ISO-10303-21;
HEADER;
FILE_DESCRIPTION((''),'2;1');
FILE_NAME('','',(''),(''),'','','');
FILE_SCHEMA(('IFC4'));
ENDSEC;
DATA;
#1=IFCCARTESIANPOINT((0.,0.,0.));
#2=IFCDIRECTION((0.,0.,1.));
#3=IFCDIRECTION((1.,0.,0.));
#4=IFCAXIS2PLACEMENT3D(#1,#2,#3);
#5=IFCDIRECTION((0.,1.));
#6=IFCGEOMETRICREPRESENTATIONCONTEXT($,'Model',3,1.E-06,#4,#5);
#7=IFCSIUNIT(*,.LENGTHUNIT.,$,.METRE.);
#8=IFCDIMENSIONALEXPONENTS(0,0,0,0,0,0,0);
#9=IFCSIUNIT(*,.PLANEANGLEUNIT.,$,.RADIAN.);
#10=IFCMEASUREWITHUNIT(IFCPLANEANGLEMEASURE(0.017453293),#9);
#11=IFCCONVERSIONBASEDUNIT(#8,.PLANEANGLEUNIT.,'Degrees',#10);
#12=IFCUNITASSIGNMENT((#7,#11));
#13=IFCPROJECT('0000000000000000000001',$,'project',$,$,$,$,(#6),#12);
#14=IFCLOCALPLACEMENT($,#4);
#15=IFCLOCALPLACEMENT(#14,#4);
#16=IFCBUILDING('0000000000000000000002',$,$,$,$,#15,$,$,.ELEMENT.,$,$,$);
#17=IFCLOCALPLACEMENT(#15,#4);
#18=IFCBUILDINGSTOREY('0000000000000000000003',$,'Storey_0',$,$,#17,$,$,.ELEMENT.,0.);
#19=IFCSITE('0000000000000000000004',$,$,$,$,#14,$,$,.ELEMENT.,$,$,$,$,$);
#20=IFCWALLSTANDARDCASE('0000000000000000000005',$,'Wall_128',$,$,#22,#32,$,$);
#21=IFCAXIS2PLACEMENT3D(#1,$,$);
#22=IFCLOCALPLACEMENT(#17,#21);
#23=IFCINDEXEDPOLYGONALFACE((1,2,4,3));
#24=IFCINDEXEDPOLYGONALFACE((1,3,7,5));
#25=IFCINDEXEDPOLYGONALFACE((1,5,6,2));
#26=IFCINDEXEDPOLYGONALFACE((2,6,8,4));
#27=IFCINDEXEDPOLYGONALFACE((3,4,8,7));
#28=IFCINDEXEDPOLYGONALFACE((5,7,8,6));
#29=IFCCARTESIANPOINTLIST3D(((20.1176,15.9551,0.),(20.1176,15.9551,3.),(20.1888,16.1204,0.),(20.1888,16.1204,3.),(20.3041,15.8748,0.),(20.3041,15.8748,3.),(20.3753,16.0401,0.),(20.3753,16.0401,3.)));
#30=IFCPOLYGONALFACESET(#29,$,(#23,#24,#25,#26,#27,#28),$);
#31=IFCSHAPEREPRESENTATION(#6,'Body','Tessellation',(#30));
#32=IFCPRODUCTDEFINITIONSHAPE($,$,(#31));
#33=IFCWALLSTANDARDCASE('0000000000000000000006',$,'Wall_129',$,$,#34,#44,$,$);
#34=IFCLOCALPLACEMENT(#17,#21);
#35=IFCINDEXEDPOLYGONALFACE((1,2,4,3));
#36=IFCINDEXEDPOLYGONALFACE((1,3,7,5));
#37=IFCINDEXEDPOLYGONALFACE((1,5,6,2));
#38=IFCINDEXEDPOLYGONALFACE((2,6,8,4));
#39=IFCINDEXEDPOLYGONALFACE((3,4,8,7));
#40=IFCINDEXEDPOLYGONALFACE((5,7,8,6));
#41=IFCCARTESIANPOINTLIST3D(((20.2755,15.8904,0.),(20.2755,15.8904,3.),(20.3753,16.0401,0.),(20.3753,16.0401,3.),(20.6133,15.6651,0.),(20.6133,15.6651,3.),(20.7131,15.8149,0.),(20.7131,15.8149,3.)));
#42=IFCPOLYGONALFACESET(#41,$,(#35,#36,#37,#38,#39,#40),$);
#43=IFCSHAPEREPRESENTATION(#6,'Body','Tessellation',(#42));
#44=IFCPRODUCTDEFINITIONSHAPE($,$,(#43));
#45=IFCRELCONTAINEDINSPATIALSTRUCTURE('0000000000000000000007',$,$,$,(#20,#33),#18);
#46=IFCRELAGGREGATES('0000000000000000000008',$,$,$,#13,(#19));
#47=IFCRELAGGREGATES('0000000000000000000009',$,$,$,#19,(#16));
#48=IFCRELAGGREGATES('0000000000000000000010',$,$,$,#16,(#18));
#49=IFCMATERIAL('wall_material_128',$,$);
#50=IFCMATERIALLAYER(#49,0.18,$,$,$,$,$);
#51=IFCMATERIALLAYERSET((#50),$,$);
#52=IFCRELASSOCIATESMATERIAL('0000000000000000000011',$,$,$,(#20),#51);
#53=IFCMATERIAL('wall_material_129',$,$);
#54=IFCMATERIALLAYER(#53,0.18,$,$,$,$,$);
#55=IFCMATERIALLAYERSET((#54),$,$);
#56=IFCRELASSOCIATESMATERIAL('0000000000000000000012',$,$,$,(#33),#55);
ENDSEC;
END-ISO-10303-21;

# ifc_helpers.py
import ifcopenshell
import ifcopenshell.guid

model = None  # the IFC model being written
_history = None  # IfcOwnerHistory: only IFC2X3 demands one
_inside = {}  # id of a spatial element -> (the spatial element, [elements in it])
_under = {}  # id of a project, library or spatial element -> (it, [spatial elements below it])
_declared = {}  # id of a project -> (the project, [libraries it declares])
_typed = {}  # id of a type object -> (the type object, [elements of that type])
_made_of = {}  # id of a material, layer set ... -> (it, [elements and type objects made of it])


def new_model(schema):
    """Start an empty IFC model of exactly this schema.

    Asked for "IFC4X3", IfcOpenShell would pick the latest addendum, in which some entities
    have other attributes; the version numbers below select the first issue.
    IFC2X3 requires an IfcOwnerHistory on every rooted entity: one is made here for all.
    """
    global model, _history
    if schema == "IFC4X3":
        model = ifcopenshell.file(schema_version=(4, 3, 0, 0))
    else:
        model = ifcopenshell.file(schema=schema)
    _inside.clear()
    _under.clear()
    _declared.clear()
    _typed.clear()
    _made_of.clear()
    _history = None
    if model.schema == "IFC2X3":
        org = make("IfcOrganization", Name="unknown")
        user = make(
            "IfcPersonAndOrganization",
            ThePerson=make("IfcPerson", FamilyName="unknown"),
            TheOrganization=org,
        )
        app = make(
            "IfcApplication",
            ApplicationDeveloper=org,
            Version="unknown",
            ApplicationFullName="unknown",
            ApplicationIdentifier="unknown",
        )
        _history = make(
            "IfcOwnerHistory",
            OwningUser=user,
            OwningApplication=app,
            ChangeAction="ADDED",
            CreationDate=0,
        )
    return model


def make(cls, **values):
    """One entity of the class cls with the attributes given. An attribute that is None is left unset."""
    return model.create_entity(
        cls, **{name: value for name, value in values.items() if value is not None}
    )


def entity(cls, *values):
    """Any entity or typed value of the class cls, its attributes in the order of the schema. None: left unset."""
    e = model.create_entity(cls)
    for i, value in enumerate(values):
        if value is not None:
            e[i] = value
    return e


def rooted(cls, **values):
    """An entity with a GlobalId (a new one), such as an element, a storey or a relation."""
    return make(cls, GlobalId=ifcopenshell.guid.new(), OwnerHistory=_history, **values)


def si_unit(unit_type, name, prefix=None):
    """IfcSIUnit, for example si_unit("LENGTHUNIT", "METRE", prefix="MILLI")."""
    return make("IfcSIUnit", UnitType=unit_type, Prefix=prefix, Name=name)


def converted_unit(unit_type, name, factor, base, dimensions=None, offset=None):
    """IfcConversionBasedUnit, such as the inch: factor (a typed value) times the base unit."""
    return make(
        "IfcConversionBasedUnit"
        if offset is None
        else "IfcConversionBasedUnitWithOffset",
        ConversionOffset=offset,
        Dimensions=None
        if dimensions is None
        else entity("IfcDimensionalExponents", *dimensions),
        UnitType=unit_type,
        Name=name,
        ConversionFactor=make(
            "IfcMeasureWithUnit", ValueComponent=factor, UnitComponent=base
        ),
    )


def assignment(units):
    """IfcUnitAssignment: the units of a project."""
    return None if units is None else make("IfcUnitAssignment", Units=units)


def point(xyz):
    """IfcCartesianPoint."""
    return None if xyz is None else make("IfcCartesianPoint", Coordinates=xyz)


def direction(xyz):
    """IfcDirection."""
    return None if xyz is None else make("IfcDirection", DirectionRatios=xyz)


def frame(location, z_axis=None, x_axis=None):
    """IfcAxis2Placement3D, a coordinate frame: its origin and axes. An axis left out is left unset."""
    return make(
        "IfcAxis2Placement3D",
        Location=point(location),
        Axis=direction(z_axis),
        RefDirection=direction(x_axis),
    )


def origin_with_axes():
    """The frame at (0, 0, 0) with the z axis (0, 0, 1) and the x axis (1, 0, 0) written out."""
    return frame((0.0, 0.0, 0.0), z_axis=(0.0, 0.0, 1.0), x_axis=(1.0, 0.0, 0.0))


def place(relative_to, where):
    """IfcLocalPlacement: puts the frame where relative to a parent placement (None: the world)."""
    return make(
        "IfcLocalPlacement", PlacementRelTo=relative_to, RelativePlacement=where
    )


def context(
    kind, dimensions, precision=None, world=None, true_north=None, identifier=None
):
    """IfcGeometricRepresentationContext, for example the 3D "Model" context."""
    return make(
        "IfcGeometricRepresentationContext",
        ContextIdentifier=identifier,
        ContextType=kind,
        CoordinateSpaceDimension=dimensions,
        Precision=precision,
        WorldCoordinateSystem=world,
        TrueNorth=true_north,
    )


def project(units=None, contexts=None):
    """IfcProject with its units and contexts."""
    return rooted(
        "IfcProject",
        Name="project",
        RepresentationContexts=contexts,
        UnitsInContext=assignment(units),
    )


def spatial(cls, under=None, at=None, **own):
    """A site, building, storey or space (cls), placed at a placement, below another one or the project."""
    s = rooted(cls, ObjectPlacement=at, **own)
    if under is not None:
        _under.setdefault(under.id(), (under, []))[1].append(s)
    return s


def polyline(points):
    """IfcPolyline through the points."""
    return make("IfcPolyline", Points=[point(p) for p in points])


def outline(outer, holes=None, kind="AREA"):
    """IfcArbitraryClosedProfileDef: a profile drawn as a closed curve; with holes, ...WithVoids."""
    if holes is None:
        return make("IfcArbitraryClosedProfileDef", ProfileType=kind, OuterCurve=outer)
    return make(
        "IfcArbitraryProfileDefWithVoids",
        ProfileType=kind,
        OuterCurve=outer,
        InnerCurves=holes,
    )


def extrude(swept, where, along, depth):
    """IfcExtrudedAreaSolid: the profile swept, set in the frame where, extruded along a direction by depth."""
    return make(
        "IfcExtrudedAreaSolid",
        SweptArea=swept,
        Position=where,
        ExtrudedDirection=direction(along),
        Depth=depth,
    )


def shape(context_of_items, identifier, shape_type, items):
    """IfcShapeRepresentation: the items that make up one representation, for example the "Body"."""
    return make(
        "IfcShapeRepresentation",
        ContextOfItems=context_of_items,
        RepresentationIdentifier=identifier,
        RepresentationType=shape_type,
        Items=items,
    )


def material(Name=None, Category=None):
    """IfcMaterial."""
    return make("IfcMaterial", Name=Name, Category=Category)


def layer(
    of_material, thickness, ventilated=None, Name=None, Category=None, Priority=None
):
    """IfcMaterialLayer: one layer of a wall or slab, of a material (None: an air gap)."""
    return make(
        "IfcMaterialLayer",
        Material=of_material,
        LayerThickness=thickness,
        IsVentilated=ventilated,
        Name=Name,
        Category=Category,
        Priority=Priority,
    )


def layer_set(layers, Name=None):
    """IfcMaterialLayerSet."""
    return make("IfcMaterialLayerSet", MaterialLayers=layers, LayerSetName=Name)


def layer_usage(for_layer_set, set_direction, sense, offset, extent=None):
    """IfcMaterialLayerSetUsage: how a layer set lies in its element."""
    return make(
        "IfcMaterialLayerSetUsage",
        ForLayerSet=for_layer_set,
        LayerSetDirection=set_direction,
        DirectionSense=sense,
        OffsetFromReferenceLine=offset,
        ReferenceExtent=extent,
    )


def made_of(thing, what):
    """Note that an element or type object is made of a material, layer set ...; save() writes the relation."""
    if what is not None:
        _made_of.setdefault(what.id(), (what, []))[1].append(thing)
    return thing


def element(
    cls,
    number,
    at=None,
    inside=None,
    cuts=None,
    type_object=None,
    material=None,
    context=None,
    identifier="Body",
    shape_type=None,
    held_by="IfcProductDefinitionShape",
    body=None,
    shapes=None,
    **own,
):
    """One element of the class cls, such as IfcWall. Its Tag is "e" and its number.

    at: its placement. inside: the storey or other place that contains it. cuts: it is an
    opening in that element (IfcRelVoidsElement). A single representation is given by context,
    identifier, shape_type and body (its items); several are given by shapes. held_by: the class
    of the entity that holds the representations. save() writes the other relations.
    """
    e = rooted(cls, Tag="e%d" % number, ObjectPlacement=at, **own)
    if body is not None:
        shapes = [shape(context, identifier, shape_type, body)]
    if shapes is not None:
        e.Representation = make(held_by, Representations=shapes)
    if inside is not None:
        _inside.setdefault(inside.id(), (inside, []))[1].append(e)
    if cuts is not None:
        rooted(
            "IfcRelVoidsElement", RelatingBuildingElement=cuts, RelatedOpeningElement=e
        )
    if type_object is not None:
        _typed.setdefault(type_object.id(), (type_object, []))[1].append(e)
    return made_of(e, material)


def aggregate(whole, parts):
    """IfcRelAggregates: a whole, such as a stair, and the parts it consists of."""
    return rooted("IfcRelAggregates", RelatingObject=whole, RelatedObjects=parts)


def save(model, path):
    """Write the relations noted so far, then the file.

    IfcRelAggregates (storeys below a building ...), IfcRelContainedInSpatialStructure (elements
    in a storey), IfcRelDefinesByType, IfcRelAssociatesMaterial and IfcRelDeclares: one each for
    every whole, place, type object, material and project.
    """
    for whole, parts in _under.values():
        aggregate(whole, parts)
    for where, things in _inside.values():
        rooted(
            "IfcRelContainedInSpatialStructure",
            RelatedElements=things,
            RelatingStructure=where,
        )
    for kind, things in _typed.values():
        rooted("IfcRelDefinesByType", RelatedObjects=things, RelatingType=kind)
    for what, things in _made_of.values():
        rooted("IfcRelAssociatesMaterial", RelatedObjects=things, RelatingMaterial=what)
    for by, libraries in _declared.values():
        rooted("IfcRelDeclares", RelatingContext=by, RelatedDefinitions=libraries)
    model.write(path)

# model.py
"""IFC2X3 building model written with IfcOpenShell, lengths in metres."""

from ifc_helpers import new_model, entity, si_unit, converted_unit, direction, frame, origin_with_axes, place, context, project, spatial, polyline, outline, extrude, material, layer, layer_set, layer_usage, element, save


model = new_model("IFC2X3")

# Units and contexts
model_context = context("Model", 3, precision=1e-06, world=origin_with_axes(), true_north=direction((0.0, 1.0)))
ifc_project = project(units=[si_unit("LENGTHUNIT", "METRE"), converted_unit("PLANEANGLEUNIT", "Degrees", entity("IfcPlaneAngleMeasure", 0.017453293), si_unit("PLANEANGLEUNIT", "RADIAN"), dimensions=[0, 0, 0, 0, 0, 0, 0])], contexts=[model_context])

# Site, building, storey
site_placement = place(None, origin_with_axes())
site = spatial("IfcSite", under=ifc_project, at=site_placement, CompositionType="ELEMENT")
building_placement = place(site_placement, origin_with_axes())
building = spatial("IfcBuilding", under=site, at=building_placement, CompositionType="ELEMENT")
storey_placement = place(building_placement, origin_with_axes())
storey = spatial("IfcBuildingStorey", under=building, at=storey_placement, Name="Storey_0", CompositionType="ELEMENT", Elevation=0.0)

# Walls
ifc_material_1 = material(Name="wall_material_128")
ifc_layer_1 = layer(ifc_material_1, 0.18)
ifc_layer_set_1 = layer_set([ifc_layer_1])
ifc_layer_usage_1 = layer_usage(ifc_layer_set_1, "AXIS2", "NEGATIVE", 0.0)
wall_1_placement = place(storey_placement, frame((20.1888, 16.1204, 0.0), z_axis=(0.0, 0.0, 1.0), x_axis=(0.918443, -0.395553, 0.0)))
element("IfcWallStandardCase", 1, at=wall_1_placement, inside=storey, material=ifc_layer_usage_1, Name="Wall_128", context=model_context, shape_type="SweptSolid", body=[
    extrude(outline(polyline([(0.0, 0.0), (0.2031, 0.0), (0.2031, -0.18), (0.0, -0.18), (0.0, 0.0)])), origin_with_axes(), (0.0, 0.0, 1.0), 3.0),
])
ifc_material_2 = material(Name="wall_material_129")
ifc_layer_2 = layer(ifc_material_2, 0.18)
ifc_layer_set_2 = layer_set([ifc_layer_2])
ifc_layer_usage_2 = layer_usage(ifc_layer_set_2, "AXIS2", "NEGATIVE", 0.0)
wall_2_placement = place(storey_placement, frame((20.3753, 16.0401, 0.0), z_axis=(0.0, 0.0, 1.0), x_axis=(0.831998, -0.554779, 0.0)))
element("IfcWallStandardCase", 2, at=wall_2_placement, inside=storey, material=ifc_layer_usage_2, Name="Wall_129", context=model_context, shape_type="SweptSolid", body=[
    extrude(outline(polyline([(0.0, 0.0), (0.406, 0.0), (0.406, -0.18), (0.0, -0.18), (0.0, 0.0)])), origin_with_axes(), (0.0, 0.0, 1.0), 3.0),
])

save(model, "model.ifc")
